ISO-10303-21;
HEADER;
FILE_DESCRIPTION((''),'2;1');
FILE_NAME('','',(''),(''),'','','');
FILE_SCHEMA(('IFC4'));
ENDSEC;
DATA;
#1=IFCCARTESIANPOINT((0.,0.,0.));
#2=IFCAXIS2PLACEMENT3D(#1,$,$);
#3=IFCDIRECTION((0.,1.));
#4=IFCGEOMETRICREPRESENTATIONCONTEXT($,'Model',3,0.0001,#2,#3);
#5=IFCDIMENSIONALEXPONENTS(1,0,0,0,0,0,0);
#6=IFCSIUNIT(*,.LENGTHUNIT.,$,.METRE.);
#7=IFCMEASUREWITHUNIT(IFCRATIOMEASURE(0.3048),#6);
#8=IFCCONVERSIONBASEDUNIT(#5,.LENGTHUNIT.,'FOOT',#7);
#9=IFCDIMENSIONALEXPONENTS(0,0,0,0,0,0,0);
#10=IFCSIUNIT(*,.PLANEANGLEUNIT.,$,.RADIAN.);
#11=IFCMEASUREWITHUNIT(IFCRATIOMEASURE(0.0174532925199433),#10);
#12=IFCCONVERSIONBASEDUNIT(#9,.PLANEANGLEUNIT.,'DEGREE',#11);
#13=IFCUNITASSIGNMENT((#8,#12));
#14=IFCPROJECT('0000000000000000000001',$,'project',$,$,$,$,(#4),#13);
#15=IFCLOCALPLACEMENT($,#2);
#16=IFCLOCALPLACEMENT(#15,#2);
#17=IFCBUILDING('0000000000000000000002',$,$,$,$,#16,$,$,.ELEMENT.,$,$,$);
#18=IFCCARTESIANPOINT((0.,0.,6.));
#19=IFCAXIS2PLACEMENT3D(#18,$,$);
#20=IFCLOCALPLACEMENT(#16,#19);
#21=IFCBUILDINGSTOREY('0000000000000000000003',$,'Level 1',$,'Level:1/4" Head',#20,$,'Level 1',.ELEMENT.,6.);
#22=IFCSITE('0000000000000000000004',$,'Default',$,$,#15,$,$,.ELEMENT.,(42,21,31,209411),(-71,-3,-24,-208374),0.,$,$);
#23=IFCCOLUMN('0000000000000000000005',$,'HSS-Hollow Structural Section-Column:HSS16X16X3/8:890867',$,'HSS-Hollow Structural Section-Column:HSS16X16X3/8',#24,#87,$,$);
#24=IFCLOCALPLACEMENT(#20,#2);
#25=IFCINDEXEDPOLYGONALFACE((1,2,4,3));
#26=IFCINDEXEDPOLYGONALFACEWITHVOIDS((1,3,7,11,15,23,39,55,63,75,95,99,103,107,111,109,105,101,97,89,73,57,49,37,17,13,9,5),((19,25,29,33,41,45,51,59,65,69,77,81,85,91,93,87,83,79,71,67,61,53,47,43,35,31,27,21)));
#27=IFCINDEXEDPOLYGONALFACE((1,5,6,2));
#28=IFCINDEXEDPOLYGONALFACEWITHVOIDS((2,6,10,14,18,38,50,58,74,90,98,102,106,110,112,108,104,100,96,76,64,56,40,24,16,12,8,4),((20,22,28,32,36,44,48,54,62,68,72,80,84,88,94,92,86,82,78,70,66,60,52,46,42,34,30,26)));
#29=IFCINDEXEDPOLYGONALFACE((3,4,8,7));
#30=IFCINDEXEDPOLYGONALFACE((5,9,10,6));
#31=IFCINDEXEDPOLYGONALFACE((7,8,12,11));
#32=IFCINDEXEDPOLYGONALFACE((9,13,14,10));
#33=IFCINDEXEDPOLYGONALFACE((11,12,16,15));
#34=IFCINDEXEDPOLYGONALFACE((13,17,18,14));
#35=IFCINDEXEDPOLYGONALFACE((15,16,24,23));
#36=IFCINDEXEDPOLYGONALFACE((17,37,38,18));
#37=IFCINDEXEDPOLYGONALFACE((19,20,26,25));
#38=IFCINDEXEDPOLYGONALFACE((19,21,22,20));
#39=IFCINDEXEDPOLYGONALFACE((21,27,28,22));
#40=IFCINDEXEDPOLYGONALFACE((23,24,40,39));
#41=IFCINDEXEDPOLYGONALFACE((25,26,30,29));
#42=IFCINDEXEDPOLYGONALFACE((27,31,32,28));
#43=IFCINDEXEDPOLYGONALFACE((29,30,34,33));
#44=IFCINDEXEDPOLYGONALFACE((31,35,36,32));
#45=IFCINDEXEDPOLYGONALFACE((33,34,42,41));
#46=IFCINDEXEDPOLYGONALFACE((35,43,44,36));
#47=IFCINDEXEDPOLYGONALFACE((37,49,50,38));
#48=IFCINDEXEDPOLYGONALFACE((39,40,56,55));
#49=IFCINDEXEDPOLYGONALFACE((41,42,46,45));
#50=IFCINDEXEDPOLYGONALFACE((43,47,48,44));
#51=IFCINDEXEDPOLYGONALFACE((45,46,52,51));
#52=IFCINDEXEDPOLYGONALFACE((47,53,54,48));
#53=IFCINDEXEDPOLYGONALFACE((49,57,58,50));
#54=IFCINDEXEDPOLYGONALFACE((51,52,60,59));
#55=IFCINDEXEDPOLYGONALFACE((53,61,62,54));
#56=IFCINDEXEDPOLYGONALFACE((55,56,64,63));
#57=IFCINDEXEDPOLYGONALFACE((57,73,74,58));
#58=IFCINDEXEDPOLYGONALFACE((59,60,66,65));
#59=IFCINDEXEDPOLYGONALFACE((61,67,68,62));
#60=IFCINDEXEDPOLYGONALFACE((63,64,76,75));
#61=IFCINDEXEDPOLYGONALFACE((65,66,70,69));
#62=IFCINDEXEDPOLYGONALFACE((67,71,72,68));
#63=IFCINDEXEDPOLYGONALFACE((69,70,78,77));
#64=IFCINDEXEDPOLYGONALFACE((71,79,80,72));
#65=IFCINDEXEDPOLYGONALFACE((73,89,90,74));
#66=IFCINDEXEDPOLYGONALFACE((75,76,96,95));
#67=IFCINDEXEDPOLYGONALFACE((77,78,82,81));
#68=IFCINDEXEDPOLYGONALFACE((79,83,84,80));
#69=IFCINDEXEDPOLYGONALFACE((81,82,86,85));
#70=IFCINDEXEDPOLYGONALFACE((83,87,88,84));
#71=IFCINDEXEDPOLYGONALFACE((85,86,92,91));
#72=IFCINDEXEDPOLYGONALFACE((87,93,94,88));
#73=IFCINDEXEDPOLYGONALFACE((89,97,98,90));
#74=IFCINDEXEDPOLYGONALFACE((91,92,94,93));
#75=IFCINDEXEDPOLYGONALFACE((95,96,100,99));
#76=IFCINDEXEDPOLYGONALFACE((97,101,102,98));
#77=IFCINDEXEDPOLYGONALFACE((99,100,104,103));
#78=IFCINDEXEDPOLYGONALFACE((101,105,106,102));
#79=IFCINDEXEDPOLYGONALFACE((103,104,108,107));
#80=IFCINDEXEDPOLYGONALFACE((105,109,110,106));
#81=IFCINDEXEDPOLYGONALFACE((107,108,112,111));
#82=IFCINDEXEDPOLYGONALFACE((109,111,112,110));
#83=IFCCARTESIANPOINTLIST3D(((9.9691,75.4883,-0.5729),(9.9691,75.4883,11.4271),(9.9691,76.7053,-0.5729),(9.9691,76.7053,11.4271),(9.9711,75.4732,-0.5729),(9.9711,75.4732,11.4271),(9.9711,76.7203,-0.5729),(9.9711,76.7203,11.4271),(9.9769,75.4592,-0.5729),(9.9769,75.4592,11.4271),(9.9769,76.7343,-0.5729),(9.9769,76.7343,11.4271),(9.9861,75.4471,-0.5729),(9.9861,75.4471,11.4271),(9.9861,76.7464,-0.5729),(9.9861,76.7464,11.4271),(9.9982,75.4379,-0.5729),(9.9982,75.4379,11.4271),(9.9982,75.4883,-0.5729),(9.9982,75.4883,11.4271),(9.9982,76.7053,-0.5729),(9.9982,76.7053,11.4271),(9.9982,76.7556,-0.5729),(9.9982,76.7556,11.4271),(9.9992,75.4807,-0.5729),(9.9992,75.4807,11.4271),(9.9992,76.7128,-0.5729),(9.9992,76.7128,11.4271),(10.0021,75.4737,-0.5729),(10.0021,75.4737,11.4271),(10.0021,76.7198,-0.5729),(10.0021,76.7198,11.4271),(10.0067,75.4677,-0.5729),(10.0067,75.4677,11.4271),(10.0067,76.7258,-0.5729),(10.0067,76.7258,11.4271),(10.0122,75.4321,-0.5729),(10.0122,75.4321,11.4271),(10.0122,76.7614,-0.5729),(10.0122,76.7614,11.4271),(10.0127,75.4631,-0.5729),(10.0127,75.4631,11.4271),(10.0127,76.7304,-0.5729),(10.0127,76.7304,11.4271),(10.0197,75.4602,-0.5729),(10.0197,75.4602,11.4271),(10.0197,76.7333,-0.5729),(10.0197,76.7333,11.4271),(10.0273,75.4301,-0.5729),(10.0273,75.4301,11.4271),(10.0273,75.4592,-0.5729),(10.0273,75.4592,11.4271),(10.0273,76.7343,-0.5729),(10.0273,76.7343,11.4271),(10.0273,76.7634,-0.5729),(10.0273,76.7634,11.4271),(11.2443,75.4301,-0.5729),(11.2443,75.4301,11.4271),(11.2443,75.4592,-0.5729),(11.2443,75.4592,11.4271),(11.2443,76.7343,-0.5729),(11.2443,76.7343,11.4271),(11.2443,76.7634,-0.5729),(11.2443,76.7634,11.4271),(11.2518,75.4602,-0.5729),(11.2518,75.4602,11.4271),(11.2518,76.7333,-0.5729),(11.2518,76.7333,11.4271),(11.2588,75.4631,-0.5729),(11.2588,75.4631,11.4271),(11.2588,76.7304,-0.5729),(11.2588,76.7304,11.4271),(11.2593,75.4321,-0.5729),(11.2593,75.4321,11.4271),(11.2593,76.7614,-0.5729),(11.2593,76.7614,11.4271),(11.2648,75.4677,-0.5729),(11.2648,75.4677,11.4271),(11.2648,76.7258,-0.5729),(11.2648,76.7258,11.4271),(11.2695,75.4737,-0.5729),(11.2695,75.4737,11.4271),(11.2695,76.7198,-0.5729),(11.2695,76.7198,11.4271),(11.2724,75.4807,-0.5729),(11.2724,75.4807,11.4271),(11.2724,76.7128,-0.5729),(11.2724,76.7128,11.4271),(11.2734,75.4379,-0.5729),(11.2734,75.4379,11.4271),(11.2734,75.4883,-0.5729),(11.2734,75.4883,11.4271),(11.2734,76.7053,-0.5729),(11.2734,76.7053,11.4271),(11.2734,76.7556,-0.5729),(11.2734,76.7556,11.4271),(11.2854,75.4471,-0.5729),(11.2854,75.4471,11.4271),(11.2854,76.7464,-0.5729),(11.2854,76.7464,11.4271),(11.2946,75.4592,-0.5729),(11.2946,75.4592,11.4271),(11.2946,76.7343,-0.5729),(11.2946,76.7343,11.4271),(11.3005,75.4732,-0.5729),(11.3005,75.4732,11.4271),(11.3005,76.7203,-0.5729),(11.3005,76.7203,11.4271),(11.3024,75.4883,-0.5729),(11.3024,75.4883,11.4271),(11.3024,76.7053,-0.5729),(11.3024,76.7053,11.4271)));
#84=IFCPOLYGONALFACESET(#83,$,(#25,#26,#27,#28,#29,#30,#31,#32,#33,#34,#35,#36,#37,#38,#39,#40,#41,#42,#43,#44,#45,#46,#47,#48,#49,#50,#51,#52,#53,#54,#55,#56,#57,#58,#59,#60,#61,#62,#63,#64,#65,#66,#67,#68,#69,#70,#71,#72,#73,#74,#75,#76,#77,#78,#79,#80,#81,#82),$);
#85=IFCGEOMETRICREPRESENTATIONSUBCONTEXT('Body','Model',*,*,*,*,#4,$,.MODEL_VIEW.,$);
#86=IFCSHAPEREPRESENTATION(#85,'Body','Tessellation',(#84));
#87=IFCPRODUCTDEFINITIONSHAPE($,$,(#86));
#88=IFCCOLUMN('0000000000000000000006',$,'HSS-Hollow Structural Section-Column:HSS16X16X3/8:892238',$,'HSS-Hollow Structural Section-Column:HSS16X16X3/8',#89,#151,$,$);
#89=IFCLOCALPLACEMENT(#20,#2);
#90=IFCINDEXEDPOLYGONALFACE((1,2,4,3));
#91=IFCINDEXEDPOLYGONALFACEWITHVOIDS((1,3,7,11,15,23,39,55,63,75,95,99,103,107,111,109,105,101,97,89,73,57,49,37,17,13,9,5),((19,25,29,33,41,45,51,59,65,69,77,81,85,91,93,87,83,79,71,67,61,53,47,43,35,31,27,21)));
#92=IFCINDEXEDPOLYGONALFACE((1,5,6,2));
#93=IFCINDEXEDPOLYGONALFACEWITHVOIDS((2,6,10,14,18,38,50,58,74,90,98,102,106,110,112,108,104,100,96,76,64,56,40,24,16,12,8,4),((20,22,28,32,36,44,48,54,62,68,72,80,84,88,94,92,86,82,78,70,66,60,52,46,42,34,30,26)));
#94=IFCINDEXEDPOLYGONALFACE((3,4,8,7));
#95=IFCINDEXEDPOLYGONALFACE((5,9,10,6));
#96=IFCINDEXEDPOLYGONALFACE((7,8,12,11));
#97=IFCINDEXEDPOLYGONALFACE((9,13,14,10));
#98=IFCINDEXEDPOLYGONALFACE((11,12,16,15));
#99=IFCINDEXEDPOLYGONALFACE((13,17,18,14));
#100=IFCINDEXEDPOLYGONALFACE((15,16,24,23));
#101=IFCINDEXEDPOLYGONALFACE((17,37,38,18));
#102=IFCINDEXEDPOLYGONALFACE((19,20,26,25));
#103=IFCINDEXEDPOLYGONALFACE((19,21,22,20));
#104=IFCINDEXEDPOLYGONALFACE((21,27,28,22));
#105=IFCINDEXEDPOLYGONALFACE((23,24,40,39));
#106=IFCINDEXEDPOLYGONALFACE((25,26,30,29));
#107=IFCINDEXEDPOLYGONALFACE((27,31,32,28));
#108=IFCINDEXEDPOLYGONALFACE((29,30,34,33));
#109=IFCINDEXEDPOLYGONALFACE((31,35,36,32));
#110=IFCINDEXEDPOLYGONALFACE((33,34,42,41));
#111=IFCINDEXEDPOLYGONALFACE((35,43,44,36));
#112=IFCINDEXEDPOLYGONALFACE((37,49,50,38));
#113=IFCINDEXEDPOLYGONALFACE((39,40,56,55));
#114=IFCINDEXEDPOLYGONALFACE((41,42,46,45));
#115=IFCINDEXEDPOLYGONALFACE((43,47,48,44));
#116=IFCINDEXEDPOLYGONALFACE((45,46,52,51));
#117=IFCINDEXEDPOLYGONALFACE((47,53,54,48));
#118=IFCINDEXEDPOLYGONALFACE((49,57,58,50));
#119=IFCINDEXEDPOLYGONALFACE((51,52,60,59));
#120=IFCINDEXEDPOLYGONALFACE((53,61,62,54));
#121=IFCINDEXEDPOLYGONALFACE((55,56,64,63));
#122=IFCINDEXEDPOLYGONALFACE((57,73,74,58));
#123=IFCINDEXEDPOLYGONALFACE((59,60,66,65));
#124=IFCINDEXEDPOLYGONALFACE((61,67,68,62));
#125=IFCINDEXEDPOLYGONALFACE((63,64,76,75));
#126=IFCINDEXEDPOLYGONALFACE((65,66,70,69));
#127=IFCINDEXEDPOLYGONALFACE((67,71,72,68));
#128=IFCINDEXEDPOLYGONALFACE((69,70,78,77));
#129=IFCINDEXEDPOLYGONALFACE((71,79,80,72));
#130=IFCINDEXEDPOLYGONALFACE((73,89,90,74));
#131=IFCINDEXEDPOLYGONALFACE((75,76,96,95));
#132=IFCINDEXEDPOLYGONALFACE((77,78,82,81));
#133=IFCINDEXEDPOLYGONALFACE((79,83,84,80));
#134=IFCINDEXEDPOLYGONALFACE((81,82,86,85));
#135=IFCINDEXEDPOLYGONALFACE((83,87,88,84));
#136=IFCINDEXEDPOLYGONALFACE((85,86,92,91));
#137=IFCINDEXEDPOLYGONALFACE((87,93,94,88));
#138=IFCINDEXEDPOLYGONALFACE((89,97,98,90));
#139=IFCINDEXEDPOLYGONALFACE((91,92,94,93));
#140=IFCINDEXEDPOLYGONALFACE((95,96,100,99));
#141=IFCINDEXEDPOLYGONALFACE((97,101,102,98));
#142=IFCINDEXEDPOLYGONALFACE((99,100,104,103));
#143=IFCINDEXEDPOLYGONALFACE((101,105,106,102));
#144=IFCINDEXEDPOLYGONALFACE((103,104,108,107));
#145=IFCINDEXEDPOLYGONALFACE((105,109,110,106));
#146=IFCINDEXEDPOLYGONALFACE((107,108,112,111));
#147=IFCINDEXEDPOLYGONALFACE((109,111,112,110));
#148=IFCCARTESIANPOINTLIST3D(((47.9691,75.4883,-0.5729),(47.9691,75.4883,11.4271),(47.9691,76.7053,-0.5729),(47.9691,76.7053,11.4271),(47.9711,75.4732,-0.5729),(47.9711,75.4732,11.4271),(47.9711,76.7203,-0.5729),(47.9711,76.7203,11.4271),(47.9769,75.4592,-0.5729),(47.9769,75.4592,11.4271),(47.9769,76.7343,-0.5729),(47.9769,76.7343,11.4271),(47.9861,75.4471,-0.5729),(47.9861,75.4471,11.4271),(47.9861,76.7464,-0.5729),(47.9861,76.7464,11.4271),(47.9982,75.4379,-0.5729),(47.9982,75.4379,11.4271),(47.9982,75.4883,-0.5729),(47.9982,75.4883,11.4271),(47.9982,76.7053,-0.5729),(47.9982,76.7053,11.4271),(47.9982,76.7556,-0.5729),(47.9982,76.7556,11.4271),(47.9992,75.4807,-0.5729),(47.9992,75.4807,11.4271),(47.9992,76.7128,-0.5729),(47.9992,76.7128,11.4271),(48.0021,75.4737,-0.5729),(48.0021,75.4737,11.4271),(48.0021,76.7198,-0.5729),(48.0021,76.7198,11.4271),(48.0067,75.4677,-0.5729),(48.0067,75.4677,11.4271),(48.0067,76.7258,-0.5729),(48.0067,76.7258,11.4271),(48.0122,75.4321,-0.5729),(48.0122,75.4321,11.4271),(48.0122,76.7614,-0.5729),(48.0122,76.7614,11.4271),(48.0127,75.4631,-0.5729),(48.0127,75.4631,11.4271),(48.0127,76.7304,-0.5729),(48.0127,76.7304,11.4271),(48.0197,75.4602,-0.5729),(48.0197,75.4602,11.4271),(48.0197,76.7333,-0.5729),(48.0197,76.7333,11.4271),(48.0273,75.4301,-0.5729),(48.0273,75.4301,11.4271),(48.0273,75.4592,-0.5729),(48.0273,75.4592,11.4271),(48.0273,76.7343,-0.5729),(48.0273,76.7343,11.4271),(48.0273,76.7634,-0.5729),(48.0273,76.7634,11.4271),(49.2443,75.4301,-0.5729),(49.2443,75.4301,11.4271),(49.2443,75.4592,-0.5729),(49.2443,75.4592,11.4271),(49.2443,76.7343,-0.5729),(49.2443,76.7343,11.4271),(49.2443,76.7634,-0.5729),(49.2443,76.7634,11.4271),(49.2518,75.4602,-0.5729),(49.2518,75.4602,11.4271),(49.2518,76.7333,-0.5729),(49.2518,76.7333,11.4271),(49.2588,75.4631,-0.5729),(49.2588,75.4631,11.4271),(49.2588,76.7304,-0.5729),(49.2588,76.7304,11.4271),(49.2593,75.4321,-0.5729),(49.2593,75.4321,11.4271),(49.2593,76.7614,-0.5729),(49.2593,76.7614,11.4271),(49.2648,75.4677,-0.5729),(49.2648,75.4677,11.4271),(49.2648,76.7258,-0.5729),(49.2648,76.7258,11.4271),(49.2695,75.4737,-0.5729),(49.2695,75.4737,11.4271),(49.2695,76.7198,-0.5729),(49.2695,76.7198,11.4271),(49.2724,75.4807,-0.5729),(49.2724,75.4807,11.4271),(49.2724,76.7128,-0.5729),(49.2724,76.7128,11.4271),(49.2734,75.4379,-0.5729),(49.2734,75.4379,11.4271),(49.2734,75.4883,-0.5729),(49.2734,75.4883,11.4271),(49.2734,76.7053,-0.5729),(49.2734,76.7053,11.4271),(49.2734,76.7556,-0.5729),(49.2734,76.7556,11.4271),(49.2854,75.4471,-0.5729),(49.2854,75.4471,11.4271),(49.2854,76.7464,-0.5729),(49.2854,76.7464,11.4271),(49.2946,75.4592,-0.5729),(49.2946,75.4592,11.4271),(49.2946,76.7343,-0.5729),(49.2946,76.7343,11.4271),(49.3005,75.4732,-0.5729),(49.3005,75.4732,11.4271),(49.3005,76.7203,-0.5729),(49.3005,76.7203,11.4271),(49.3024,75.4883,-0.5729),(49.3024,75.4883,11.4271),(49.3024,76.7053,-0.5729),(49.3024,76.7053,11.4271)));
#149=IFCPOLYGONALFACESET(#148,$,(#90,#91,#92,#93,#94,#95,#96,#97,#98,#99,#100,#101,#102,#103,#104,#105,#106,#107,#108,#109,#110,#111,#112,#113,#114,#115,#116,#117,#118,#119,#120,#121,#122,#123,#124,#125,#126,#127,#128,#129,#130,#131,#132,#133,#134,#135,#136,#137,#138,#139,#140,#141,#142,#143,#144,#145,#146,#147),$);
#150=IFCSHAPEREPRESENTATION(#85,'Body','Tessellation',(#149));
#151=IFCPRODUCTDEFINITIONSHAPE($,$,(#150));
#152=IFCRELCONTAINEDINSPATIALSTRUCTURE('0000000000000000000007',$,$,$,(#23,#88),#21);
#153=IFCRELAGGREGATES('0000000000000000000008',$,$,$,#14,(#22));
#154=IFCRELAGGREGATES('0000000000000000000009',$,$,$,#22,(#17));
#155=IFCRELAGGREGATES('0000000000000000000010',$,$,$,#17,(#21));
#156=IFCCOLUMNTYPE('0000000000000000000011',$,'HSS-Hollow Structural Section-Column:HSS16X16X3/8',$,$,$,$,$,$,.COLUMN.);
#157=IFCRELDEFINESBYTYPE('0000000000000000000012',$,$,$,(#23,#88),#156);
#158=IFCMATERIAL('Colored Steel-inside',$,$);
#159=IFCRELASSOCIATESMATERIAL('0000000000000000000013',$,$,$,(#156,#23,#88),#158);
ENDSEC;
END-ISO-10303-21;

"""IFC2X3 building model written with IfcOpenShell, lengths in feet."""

from ifc_helpers import new_model, entity, si_unit, converted_unit, direction, frame, frame_2d, origin, place, context, subcontext, project, spatial, polyline, circle_curve, parameter, trimmed, segment, composite_curve, outline, extrude, source, transform, mapped, material, type_object, type_shapes, element, save


model = new_model("IFC2X3")

# Units and contexts
model_context = context("Model", 3, precision=0.0001, world=origin(), true_north=direction((0.0, 1.0)))
body_context = subcontext(model_context, "Body", "Model", "MODEL_VIEW")
ifc_project = project(units=[converted_unit("LENGTHUNIT", "FOOT", entity("IfcRatioMeasure", 0.3048), si_unit("LENGTHUNIT", "METRE"), dimensions=[1, 0, 0, 0, 0, 0, 0]), converted_unit("PLANEANGLEUNIT", "DEGREE", entity("IfcRatioMeasure", 0.0174532925199433), si_unit("PLANEANGLEUNIT", "RADIAN"), dimensions=[0, 0, 0, 0, 0, 0, 0])], contexts=[model_context])

# Site, building, storey
site_placement = place(None, origin())
site = spatial("IfcSite", under=ifc_project, at=site_placement, Name="Default", CompositionType="ELEMENT", RefLatitude=(42, 21, 31, 209411), RefLongitude=(-71, -3, -24, -208374), RefElevation=0.0)
building_placement = place(site_placement, origin())
building = spatial("IfcBuilding", under=site, at=building_placement, CompositionType="ELEMENT")
storey_placement = place(building_placement, frame((0.0, 0.0, 6.0)))
storey = spatial("IfcBuildingStorey", under=building, at=storey_placement, Name="Level 1", ObjectType="Level:1/4\" Head", LongName="Level 1", CompositionType="ELEMENT", Elevation=6.0)

# Columns
ifc_material_1 = material(Name="Colored Steel-inside")
column_type_1 = type_object("IfcColumnType", Name="HSS-Hollow Structural Section-Column:HSS16X16X3/8", PredefinedType="COLUMN", material=ifc_material_1)
shared_shape_1 = source(origin(), body_context, "Body", "SweptSolid", [
    extrude(outline(composite_curve([segment(polyline([(-0.6085, -0.6667), (0.6085, -0.6667)]), True, "CONTINUOUS"), segment(trimmed(circle_curve(frame_2d((0.6085, -0.6085), x_axis=(-1.0, 0.0)), 0.0582), [parameter(90.0)], [parameter(180.0)], True, "PARAMETER"), True, "CONTINUOUS"), segment(polyline([(0.6667, -0.6085), (0.6667, 0.6085)]), True, "CONTINUOUS"), segment(trimmed(circle_curve(frame_2d((0.6085, 0.6085), x_axis=(-1.0, 0.0)), 0.0582), [parameter(180.0)], [parameter(270.0)], True, "PARAMETER"), True, "CONTINUOUS"), segment(polyline([(0.6085, 0.6667), (-0.6085, 0.6667)]), True, "CONTINUOUS"), segment(trimmed(circle_curve(frame_2d((-0.6085, 0.6085), x_axis=(-1.0, 0.0)), 0.0582), [parameter(270.0)], [parameter(360.0)], True, "PARAMETER"), True, "CONTINUOUS"), segment(polyline([(-0.6667, 0.6085), (-0.6667, -0.6085)]), True, "CONTINUOUS"), segment(trimmed(circle_curve(frame_2d((-0.6085, -0.6085), x_axis=(-1.0, 0.0)), 0.0582), [parameter(360.0)], [parameter(90.0)], True, "PARAMETER"), True, "CONTINUOUS")], self_intersect=False), holes=[composite_curve([segment(trimmed(circle_curve(frame_2d((-0.6085, -0.6085), x_axis=(-1.0, 0.0)), 0.0291), [parameter(0.0)], [parameter(90.0)], True, "PARAMETER"), False, "CONTINUOUS"), segment(polyline([(-0.6376, -0.6085), (-0.6376, 0.6085)]), True, "CONTINUOUS"), segment(trimmed(circle_curve(frame_2d((-0.6085, 0.6085), x_axis=(-1.0, 0.0)), 0.0291), [parameter(270.0)], [parameter(360.0)], True, "PARAMETER"), False, "CONTINUOUS"), segment(polyline([(-0.6085, 0.6376), (0.6085, 0.6376)]), True, "CONTINUOUS"), segment(trimmed(circle_curve(frame_2d((0.6085, 0.6085), x_axis=(-1.0, 0.0)), 0.0291), [parameter(180.0)], [parameter(270.0)], True, "PARAMETER"), False, "CONTINUOUS"), segment(polyline([(0.6376, 0.6085), (0.6376, -0.6085)]), True, "CONTINUOUS"), segment(trimmed(circle_curve(frame_2d((0.6085, -0.6085), x_axis=(-1.0, 0.0)), 0.0291), [parameter(90.0)], [parameter(180.0)], True, "PARAMETER"), False, "CONTINUOUS"), segment(polyline([(0.6085, -0.6376), (-0.6085, -0.6376)]), True, "CONTINUOUS")], self_intersect=False)]), frame((0.0, 0.0, 5.4271), z_axis=(0.0, 0.0, 1.0), x_axis=(-1.0, 0.0, 0.0)), (0.0, 0.0, 1.0), 12.0),
])
type_shapes(column_type_1, [shared_shape_1])
for number, where, name in (
    (1, (10.6358, 76.0968, -6.0), "HSS-Hollow Structural Section-Column:HSS16X16X3/8:890867"),
    (2, (48.6358, 76.0968, -6.0), "HSS-Hollow Structural Section-Column:HSS16X16X3/8:892238"),
):
    element("IfcColumn", number, at=place(storey_placement, frame(where)), inside=storey, type_object=column_type_1, material=ifc_material_1, Name=name, ObjectType="HSS-Hollow Structural Section-Column:HSS16X16X3/8", context=body_context, shape_type="MappedRepresentation", body=[
        mapped(shared_shape_1, transform((0.0, 0.0, 0.0), scale=1.0)),
    ])

save(model, "model.ifc")
